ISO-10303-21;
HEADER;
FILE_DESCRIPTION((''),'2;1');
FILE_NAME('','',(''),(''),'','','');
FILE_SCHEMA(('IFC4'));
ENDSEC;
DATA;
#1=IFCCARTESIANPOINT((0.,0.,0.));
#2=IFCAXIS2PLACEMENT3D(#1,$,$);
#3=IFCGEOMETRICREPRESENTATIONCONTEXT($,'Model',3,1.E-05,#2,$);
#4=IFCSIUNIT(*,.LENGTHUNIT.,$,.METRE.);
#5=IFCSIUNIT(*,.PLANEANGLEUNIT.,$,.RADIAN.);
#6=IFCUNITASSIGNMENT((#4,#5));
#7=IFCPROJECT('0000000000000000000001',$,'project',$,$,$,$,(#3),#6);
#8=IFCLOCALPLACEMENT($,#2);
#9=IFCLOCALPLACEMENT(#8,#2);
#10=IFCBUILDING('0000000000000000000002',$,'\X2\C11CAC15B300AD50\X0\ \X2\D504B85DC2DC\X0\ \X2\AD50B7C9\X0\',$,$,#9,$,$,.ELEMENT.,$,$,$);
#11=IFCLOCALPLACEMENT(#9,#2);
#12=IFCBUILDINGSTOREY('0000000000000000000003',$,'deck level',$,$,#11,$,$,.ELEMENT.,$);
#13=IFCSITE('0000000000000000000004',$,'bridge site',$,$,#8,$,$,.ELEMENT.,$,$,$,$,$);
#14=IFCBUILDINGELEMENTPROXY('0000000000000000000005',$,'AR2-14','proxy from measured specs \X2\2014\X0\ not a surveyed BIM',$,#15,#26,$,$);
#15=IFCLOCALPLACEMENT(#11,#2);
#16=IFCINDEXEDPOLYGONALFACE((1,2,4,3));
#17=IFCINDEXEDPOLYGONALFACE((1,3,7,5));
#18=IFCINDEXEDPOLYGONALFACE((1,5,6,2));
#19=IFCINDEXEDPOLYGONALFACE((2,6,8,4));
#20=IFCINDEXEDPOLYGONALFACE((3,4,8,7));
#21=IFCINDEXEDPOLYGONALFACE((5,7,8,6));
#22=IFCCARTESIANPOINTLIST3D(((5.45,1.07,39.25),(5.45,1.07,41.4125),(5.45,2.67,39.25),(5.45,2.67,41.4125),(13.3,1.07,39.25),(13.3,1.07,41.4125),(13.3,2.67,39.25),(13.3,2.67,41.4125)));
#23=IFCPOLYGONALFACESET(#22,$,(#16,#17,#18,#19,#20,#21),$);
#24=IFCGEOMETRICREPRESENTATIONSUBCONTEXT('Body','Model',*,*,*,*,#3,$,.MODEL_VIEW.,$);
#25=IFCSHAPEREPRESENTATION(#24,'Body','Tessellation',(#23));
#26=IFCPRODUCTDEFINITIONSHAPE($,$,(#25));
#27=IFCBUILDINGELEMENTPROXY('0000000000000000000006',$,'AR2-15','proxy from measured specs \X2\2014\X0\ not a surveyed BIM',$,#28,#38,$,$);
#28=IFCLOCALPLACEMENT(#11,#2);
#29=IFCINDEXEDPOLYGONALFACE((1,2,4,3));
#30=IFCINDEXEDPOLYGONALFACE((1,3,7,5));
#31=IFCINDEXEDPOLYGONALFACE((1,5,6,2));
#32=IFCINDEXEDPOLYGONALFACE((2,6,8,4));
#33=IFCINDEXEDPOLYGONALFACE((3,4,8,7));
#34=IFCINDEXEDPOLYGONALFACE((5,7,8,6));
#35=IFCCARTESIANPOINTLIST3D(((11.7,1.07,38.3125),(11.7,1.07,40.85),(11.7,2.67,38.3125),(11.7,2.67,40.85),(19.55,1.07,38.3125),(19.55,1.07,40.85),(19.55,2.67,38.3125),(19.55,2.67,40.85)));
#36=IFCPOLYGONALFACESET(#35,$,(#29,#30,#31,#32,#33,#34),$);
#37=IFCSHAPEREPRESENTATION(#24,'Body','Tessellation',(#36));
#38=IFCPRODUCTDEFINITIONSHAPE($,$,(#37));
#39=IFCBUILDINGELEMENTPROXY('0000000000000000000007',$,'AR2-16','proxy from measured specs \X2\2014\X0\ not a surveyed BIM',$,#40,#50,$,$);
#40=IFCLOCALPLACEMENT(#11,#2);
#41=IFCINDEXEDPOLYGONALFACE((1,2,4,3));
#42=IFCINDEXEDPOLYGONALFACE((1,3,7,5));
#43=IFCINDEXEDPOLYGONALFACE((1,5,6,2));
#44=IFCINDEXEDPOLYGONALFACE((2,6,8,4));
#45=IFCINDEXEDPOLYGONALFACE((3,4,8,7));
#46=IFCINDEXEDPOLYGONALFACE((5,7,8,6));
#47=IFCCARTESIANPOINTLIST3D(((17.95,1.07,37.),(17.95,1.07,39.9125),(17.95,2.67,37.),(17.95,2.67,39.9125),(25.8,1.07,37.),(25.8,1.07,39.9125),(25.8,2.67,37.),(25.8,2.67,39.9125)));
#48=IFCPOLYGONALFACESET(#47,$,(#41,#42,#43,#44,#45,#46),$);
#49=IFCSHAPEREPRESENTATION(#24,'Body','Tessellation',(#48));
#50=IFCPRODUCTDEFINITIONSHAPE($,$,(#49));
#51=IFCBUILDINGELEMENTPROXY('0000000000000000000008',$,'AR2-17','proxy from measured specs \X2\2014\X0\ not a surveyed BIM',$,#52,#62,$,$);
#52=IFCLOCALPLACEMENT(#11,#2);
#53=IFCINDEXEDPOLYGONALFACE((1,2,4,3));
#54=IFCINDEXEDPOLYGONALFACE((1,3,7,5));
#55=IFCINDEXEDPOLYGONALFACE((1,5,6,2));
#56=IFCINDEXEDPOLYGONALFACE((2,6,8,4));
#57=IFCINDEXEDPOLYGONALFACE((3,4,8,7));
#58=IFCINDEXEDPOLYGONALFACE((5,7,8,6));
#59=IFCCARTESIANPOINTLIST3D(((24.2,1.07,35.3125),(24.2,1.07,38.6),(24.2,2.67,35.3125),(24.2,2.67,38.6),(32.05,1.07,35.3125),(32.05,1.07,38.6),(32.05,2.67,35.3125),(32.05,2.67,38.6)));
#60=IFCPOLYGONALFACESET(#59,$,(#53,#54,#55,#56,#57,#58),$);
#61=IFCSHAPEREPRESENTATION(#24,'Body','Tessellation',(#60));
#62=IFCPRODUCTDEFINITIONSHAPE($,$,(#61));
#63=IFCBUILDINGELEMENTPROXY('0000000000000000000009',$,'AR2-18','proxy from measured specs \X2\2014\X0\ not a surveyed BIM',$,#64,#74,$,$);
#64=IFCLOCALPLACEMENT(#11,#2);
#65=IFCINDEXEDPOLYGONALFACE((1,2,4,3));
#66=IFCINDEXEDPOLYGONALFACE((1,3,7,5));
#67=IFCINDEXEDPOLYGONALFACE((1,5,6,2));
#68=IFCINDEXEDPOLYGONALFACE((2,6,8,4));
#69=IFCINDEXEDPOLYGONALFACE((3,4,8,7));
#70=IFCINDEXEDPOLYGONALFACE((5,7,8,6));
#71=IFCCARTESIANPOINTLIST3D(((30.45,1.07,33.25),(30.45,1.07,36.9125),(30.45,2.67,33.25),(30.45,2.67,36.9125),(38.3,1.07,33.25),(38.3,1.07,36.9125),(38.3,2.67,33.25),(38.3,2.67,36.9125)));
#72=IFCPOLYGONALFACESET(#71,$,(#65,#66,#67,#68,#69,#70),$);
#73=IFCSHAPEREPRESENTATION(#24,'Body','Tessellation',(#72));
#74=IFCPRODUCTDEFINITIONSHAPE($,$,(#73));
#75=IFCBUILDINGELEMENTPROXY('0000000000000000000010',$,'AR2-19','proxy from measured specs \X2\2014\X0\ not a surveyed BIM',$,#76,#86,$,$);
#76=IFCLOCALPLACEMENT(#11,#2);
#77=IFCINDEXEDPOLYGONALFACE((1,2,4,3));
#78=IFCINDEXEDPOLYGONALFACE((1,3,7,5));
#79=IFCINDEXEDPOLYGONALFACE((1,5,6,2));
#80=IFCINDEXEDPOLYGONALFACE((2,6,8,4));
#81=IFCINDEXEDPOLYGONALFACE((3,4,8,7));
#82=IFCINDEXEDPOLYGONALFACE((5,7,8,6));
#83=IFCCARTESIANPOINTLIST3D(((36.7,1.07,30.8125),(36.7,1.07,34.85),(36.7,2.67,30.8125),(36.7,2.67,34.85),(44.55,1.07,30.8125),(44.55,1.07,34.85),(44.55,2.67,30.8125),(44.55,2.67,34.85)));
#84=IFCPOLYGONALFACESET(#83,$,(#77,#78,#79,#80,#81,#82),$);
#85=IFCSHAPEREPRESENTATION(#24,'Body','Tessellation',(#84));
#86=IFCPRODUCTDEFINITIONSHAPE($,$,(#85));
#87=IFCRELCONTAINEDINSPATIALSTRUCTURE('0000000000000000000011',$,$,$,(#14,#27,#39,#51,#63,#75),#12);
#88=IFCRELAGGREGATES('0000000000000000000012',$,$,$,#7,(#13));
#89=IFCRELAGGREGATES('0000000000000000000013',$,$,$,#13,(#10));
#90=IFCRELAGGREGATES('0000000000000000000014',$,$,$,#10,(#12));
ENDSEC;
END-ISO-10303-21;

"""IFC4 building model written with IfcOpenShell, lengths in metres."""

from ifc_helpers import new_model, si_unit, frame, origin, origin_2d, place, context, subcontext, project, spatial, rectangle, extrude, element, save


model = new_model("IFC4")

# Units and contexts
model_context = context("Model", 3, precision=1e-05, world=origin())
body_context = subcontext(model_context, "Body", "Model", "MODEL_VIEW")
ifc_project = project(units=[si_unit("LENGTHUNIT", "METRE"), si_unit("PLANEANGLEUNIT", "RADIAN")], contexts=[model_context])

# Site, building, storey
site_placement = place(None, origin())
site = spatial("IfcSite", under=ifc_project, at=site_placement, Name="bridge site", CompositionType="ELEMENT")
building_placement = place(site_placement, origin())
building = spatial("IfcBuilding", under=site, at=building_placement, Name="서강대교 프록시 교량", CompositionType="ELEMENT")
storey_placement = place(building_placement, origin())
storey = spatial("IfcBuildingStorey", under=building, at=storey_placement, Name="deck level", CompositionType="ELEMENT")

# Building element proxies
proxy_1_placement = place(storey_placement, frame((9.375, 1.87, 39.25)))
element("IfcBuildingElementProxy", 1, at=proxy_1_placement, inside=storey, Name="AR2-14", Description="proxy from measured specs — not a surveyed BIM", context=body_context, shape_type="SweptSolid", body=[
    extrude(rectangle(XDim=7.85, YDim=1.6, at=origin_2d()), origin(), (0.0, 0.0, 1.0), 2.1625),
])
proxy_2_placement = place(storey_placement, frame((15.625, 1.87, 38.3125)))
element("IfcBuildingElementProxy", 2, at=proxy_2_placement, inside=storey, Name="AR2-15", Description="proxy from measured specs — not a surveyed BIM", context=body_context, shape_type="SweptSolid", body=[
    extrude(rectangle(XDim=7.85, YDim=1.6, at=origin_2d()), origin(), (0.0, 0.0, 1.0), 2.5375),
])
proxy_3_placement = place(storey_placement, frame((21.875, 1.87, 37.0)))
element("IfcBuildingElementProxy", 3, at=proxy_3_placement, inside=storey, Name="AR2-16", Description="proxy from measured specs — not a surveyed BIM", context=body_context, shape_type="SweptSolid", body=[
    extrude(rectangle(XDim=7.85, YDim=1.6, at=origin_2d()), origin(), (0.0, 0.0, 1.0), 2.9125),
])
proxy_4_placement = place(storey_placement, frame((28.125, 1.87, 35.3125)))
element("IfcBuildingElementProxy", 4, at=proxy_4_placement, inside=storey, Name="AR2-17", Description="proxy from measured specs — not a surveyed BIM", context=body_context, shape_type="SweptSolid", body=[
    extrude(rectangle(XDim=7.85, YDim=1.6, at=origin_2d()), origin(), (0.0, 0.0, 1.0), 3.2875),
])
proxy_5_placement = place(storey_placement, frame((34.375, 1.87, 33.25)))
element("IfcBuildingElementProxy", 5, at=proxy_5_placement, inside=storey, Name="AR2-18", Description="proxy from measured specs — not a surveyed BIM", context=body_context, shape_type="SweptSolid", body=[
    extrude(rectangle(XDim=7.85, YDim=1.6, at=origin_2d()), origin(), (0.0, 0.0, 1.0), 3.6625),
])
proxy_6_placement = place(storey_placement, frame((40.625, 1.87, 30.8125)))
element("IfcBuildingElementProxy", 6, at=proxy_6_placement, inside=storey, Name="AR2-19", Description="proxy from measured specs — not a surveyed BIM", context=body_context, shape_type="SweptSolid", body=[
    extrude(rectangle(XDim=7.85, YDim=1.6, at=origin_2d()), origin(), (0.0, 0.0, 1.0), 4.0375),
])

save(model, "model.ifc")
